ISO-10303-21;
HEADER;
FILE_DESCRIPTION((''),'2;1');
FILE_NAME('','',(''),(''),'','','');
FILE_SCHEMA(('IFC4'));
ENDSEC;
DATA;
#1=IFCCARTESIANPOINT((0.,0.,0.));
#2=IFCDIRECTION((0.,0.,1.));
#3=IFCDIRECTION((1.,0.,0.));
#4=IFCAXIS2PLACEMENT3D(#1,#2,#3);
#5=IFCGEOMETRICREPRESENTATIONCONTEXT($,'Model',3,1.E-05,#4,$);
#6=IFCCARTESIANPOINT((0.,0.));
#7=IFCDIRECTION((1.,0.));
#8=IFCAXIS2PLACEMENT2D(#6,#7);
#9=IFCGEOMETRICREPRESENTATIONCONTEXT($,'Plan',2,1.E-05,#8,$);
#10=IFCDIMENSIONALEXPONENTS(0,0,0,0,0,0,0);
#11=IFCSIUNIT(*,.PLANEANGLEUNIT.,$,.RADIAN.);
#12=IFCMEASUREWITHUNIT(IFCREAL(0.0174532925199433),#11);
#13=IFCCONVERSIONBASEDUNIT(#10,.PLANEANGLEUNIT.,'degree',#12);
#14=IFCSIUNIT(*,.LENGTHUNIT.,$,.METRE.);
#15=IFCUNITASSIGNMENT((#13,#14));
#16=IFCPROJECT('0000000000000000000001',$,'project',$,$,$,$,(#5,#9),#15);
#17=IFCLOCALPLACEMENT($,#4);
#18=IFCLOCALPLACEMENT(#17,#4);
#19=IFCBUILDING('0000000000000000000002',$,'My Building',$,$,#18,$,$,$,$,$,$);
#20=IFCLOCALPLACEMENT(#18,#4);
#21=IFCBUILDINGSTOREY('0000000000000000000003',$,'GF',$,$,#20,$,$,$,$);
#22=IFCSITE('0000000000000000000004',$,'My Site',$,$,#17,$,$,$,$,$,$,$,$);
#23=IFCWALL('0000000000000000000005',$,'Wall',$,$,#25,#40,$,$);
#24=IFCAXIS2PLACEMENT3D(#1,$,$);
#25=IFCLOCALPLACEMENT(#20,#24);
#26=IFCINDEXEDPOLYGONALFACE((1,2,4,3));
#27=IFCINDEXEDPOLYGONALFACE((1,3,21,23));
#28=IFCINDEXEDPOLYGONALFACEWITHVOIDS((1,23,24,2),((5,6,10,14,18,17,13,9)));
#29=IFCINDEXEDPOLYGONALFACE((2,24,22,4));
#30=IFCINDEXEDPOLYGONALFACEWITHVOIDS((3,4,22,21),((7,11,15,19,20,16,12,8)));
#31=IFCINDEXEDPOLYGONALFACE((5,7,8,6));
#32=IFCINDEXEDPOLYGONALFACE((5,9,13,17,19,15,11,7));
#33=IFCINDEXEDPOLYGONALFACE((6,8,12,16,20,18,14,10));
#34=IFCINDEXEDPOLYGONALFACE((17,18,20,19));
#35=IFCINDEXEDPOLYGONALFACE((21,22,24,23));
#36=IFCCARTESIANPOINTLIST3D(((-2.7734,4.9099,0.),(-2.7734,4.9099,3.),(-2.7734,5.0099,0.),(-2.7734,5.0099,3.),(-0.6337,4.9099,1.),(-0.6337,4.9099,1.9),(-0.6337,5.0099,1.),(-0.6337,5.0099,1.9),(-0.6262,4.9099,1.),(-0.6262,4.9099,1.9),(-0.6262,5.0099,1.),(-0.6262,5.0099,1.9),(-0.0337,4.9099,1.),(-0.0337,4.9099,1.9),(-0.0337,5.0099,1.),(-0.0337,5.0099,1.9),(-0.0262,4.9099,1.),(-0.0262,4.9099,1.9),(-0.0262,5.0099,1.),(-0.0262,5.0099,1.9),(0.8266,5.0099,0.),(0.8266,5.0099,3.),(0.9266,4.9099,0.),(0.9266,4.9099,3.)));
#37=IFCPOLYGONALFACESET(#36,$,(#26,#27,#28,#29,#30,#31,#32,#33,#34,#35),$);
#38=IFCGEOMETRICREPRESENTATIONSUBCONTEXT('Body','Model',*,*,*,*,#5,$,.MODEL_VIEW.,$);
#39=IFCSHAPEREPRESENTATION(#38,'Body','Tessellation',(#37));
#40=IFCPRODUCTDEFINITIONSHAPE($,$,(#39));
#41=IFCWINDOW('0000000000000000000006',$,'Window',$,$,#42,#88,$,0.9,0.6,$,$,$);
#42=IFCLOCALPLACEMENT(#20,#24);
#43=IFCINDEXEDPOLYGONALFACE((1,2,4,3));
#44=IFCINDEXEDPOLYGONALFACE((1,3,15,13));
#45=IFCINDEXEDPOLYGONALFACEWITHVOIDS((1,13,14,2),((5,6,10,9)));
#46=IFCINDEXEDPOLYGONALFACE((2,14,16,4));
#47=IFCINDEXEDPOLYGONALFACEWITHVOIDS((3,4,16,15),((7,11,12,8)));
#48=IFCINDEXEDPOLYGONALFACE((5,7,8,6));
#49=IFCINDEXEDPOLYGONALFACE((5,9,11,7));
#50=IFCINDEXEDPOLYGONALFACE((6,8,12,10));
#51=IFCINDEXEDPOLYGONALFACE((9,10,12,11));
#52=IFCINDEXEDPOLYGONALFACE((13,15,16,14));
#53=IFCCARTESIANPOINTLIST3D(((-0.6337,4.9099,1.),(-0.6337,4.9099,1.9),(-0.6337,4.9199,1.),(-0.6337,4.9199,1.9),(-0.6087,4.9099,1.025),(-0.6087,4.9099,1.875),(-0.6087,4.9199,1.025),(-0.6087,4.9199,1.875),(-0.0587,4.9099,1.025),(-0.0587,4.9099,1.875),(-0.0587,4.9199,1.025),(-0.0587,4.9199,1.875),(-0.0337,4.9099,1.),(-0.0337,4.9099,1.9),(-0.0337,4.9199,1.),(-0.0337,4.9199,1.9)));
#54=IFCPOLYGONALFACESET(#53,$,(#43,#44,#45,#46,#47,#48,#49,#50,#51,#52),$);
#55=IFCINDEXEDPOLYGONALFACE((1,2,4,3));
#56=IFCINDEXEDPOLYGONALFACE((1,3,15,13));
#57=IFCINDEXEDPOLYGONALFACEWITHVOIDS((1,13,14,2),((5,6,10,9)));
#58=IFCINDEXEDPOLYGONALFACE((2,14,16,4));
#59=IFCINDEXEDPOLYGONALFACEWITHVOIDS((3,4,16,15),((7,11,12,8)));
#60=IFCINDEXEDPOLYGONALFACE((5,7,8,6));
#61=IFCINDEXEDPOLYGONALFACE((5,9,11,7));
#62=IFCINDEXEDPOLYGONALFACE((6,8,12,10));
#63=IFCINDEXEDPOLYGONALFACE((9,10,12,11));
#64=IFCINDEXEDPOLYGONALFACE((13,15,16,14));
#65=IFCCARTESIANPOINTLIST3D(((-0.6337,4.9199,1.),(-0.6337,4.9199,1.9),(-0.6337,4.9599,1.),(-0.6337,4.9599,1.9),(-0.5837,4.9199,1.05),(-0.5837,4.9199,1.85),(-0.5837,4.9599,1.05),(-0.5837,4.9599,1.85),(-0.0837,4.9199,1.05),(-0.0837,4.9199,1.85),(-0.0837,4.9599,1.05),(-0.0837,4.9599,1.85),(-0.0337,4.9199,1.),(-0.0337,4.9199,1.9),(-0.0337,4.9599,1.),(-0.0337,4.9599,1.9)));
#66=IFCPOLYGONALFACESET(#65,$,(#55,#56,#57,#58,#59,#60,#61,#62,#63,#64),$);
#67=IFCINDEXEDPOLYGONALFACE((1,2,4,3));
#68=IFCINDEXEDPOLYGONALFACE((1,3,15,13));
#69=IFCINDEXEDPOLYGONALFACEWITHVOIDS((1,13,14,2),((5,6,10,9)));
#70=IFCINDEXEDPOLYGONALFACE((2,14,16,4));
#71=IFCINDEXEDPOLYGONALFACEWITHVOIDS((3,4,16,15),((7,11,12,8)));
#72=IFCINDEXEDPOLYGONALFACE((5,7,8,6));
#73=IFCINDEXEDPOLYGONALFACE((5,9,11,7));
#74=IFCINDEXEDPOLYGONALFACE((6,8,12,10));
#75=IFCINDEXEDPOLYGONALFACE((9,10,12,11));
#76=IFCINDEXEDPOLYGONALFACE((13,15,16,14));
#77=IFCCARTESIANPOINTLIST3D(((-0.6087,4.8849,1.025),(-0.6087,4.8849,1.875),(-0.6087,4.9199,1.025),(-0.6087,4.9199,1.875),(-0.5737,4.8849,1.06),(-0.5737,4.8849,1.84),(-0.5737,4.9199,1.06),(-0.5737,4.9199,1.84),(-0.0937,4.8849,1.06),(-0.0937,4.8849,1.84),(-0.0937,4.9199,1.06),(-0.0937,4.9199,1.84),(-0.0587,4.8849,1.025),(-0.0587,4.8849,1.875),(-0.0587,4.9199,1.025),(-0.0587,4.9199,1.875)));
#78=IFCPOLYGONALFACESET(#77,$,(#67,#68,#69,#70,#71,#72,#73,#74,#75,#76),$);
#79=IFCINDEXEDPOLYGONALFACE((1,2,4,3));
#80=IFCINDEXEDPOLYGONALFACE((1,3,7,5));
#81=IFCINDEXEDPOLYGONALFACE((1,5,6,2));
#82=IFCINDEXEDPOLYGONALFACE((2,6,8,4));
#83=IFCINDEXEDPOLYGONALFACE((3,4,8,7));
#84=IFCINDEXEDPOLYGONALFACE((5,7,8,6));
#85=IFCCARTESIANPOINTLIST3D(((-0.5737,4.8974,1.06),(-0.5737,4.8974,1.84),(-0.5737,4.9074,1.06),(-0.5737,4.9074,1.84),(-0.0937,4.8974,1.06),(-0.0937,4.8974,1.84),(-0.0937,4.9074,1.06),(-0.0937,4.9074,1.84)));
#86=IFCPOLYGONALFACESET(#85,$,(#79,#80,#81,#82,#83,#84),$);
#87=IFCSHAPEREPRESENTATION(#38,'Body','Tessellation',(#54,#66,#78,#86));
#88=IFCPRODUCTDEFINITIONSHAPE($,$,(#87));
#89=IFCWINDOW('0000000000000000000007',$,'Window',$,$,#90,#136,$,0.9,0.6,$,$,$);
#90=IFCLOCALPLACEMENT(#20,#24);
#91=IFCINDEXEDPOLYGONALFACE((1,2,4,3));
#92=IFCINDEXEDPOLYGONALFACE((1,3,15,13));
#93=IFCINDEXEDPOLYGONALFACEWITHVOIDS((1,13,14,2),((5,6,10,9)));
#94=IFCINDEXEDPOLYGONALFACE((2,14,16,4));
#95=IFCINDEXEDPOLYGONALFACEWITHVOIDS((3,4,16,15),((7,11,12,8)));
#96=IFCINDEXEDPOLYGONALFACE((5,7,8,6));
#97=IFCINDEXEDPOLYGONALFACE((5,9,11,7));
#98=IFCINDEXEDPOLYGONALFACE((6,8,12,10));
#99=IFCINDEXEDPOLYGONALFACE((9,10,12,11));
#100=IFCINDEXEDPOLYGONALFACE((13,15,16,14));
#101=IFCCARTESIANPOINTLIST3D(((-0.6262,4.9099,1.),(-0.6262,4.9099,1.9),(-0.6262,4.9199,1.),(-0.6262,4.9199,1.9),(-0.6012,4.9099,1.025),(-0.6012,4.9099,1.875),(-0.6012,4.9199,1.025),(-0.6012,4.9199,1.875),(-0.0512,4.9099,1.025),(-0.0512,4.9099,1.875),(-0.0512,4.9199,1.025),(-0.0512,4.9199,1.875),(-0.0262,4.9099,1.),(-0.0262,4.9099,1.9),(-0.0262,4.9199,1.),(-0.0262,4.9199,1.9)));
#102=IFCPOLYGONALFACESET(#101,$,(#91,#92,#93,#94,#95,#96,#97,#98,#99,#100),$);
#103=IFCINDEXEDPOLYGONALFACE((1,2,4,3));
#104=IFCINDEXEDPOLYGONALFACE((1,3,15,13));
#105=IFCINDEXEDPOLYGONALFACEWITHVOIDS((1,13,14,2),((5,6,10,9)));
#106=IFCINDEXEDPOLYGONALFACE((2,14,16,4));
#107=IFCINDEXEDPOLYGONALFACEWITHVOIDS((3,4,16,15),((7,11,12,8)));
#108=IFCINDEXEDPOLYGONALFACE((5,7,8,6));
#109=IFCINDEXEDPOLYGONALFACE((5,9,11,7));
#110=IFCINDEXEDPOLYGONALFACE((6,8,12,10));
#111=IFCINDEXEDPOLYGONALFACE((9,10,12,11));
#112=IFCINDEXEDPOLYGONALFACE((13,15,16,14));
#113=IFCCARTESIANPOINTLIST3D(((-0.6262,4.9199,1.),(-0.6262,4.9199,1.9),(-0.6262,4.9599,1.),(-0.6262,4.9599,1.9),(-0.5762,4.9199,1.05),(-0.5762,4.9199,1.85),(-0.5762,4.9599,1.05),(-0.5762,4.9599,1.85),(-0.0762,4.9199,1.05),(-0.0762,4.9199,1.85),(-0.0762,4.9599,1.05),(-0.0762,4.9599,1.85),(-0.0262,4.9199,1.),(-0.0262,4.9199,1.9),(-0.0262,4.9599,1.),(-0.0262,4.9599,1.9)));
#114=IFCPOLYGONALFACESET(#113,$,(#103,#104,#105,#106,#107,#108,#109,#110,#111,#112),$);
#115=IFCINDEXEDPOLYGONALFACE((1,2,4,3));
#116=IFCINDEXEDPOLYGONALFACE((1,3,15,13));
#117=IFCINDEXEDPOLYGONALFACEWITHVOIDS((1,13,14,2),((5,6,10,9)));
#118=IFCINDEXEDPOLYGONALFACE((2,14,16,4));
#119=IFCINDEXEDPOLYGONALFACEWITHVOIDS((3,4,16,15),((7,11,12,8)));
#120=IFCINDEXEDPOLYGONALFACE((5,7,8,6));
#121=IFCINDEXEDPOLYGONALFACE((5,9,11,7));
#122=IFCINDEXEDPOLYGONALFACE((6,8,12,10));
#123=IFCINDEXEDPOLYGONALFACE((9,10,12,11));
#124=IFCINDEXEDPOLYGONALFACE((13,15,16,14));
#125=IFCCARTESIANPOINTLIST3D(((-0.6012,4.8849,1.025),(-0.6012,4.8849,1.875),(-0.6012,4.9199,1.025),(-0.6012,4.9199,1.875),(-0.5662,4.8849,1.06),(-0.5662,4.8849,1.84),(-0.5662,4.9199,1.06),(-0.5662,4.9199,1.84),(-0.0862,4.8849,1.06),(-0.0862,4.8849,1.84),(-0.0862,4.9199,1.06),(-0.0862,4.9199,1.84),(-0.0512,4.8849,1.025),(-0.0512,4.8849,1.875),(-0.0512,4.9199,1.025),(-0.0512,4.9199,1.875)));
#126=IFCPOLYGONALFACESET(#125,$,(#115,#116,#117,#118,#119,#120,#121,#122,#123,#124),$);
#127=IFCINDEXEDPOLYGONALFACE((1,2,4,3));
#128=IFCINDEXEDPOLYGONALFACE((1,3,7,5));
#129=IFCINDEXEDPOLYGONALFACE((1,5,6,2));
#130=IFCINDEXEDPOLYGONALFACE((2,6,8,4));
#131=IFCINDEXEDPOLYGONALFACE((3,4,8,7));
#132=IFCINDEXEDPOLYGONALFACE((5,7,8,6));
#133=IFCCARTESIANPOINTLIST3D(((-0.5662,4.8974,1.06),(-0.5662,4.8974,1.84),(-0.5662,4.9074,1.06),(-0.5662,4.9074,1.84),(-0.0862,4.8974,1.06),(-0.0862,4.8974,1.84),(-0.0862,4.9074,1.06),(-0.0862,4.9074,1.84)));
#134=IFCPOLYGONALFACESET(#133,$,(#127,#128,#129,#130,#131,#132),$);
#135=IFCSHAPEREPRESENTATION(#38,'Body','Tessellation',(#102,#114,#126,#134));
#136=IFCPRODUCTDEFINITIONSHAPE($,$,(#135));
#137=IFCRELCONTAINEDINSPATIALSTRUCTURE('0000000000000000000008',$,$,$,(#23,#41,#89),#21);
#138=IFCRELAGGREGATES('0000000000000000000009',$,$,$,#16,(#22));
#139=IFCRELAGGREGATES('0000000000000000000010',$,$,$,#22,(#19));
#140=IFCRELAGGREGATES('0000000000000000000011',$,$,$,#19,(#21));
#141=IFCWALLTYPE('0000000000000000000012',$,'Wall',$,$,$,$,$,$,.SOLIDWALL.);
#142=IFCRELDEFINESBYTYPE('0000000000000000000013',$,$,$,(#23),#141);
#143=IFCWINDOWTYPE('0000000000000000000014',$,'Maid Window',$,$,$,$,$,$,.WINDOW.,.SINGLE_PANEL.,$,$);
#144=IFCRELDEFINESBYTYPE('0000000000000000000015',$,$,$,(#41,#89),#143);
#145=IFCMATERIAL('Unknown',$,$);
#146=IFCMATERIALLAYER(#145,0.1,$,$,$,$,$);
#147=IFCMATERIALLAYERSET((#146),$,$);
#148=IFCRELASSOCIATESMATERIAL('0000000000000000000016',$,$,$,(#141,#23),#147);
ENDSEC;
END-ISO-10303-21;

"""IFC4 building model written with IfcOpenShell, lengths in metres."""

from ifc_helpers import new_model, entity, si_unit, converted_unit, frame, origin_with_axes, origin_2d_with_axis, place, context, subcontext, project, spatial, line, indexed_curve, outline, extrude, shape, source, transform, mapped, material, layer, layer_set, layer_usage, type_object, type_shapes, element, fill, save


model = new_model("IFC4")

# Units and contexts
model_context = context("Model", 3, precision=1e-05, world=origin_with_axes())
plan_context = context("Plan", 2, precision=1e-05, world=origin_2d_with_axis())
body_context_1 = subcontext(model_context, "Body", "Model", "MODEL_VIEW")
body_context_2 = subcontext(plan_context, "Body", "Plan", "PLAN_VIEW")
ifc_project = project(units=[converted_unit("PLANEANGLEUNIT", "degree", entity("IfcReal", 0.0174532925199433), si_unit("PLANEANGLEUNIT", "RADIAN"), dimensions=[0, 0, 0, 0, 0, 0, 0]), si_unit("LENGTHUNIT", "METRE")], contexts=[model_context, plan_context])

# Site, building, storey
site_placement = place(None, origin_with_axes())
site = spatial("IfcSite", under=ifc_project, at=site_placement, Name="My Site")
building_placement = place(site_placement, origin_with_axes())
building = spatial("IfcBuilding", under=site, at=building_placement, Name="My Building")
storey_placement = place(building_placement, origin_with_axes())
storey = spatial("IfcBuildingStorey", under=building, at=storey_placement, Name="GF")

# Shared definitions
ifc_material = material(Name="Unknown")

# Shared definitions
ifc_layer_1 = layer(ifc_material, 0.1)
ifc_layer_set_1 = layer_set([ifc_layer_1])
wall_type = type_object("IfcWallType", Name="Wall", PredefinedType="SOLIDWALL", material=ifc_layer_set_1)

# Wall, openings, windows
ifc_layer_usage_1 = layer_usage(ifc_layer_set_1, "AXIS2", "POSITIVE", 0.0)
wall_1_placement = place(storey_placement, frame((0.8266, 5.0099, 0.0), z_axis=(0.0, 0.0, 1.0), x_axis=(-1.0, 0.0, 0.0)))
wall_1 = element("IfcWall", 1, at=wall_1_placement, inside=storey, type_object=wall_type, material=ifc_layer_usage_1, Name="Wall", context=body_context_1, shape_type="SweptSolid", body=[
    extrude(outline(indexed_curve([(0.0, 0.0), (-0.1, 0.1), (3.6, 0.1), (3.6, 0.0)], segments=[line(1, 2, 3, 4, 1)])), origin_with_axes(), (0.0, 0.0, 1.0), 3.0),
])
shared_shape_1 = source(origin_with_axes(), body_context_1, "Body", "SweptSolid", [
    extrude(outline(indexed_curve([(0.0, 0.0), (0.6, 0.0), (0.6, 0.9), (0.0, 0.9)], segments=[line(1, 2, 3, 4, 1)])), frame((0.0, -0.6, 0.0), z_axis=(0.0, -1.0, 0.0), x_axis=(1.0, 0.0, 0.0)), (0.0, 0.0, -1.0), 1.2),
])
opening_1_placement = place(wall_1_placement, frame((0.8604, 0.0, 1.0), z_axis=(0.0, 0.0, 1.0), x_axis=(1.0, 0.0, 0.0)))
opening_1 = element("IfcOpeningElement", 2, at=opening_1_placement, cuts=wall_1, PredefinedType="OPENING", context=body_context_1, shape_type="MappedRepresentation", body=[
    mapped(shared_shape_1, transform((0.0, 0.0, 0.0), x_axis=(1.0, 0.0, 0.0), y_axis=(0.0, 1.0, 0.0), z_axis=(0.0, 0.0, 1.0), scale=1.0)),
])
opening_2_placement = place(wall_1_placement, frame((0.8528, 0.0, 1.0), z_axis=(0.0, 0.0, 1.0), x_axis=(1.0, 0.0, 0.0)))
opening_2 = element("IfcOpeningElement", 3, at=opening_2_placement, cuts=wall_1, PredefinedType="OPENING", context=body_context_1, shape_type="MappedRepresentation", body=[
    mapped(shared_shape_1, transform((0.0, 0.0, 0.0), x_axis=(1.0, 0.0, 0.0), y_axis=(0.0, 1.0, 0.0), z_axis=(0.0, 0.0, 1.0), scale=1.0)),
])
window_type_1 = type_object("IfcWindowType", Name="Maid Window", PartitioningType="SINGLE_PANEL", PredefinedType="WINDOW")
shared_shape_2 = source(origin_with_axes(), body_context_1, "Body", "SweptSolid", [
    extrude(outline(indexed_curve([(0.0, 0.0), (0.6, 0.0), (0.6, 0.9), (0.0, 0.9)], segments=[line(1, 2, 3, 4, 1)]), holes=[indexed_curve([(0.025, 0.025), (0.575, 0.025), (0.575, 0.875), (0.025, 0.875)], segments=[line(1, 2, 3, 4, 1)])]), frame((0.0, 0.09, 0.0), z_axis=(0.0, -1.0, 0.0), x_axis=(1.0, 0.0, 0.0)), (0.0, 0.0, -1.0), 0.01),
    extrude(outline(indexed_curve([(0.0, 0.0), (0.6, 0.0), (0.6, 0.9), (0.0, 0.9)], segments=[line(1, 2, 3, 4, 1)]), holes=[indexed_curve([(0.05, 0.05), (0.55, 0.05), (0.55, 0.85), (0.05, 0.85)], segments=[line(1, 2, 3, 4, 1)])]), frame((0.0, 0.05, 0.0), z_axis=(0.0, -1.0, 0.0), x_axis=(1.0, 0.0, 0.0)), (0.0, 0.0, -1.0), 0.04),
    extrude(outline(indexed_curve([(0.0, 0.0), (0.55, 0.0), (0.55, 0.85), (0.0, 0.85)], segments=[line(1, 2, 3, 4, 1)]), holes=[indexed_curve([(0.035, 0.035), (0.515, 0.035), (0.515, 0.815), (0.035, 0.815)], segments=[line(1, 2, 3, 4, 1)])]), frame((0.025, 0.09, 0.025), z_axis=(0.0, -1.0, 0.0), x_axis=(1.0, 0.0, 0.0)), (0.0, 0.0, -1.0), 0.035),
    extrude(outline(indexed_curve([(0.035, 0.035), (0.515, 0.035), (0.515, 0.815), (0.035, 0.815)], segments=[line(1, 2, 3, 4, 1)])), frame((0.025, 0.1025, 0.025), z_axis=(0.0, -1.0, 0.0), x_axis=(1.0, 0.0, 0.0)), (0.0, 0.0, -1.0), 0.01),
])
shared_shape_3 = source(origin_with_axes(), body_context_2, "Body", "Curve2D", [
    entity("IfcIndexedPolyCurve", entity("IfcCartesianPointList2D", [[0.05, 0.05], [0.55, 0.05]])),
    entity("IfcIndexedPolyCurve", entity("IfcCartesianPointList2D", [[0.0, 0.1], [0.025, 0.1], [0.025, 0.09], [0.05, 0.09], [0.05, 0.05], [0.0, 0.05]]), [entity("IfcLineIndex", [1, 2, 3, 4, 5, 6, 1])]),
    entity("IfcIndexedPolyCurve", entity("IfcCartesianPointList2D", [[0.6, 0.1], [0.575, 0.1], [0.575, 0.09], [0.55, 0.09], [0.55, 0.05], [0.6, 0.05]]), [entity("IfcLineIndex", [1, 2, 3, 4, 5, 6, 1])]),
    entity("IfcIndexedPolyCurve", entity("IfcCartesianPointList2D", [[0.025, 0.09], [0.06, 0.09], [0.06, 0.125], [0.025, 0.125]]), [entity("IfcLineIndex", [1, 2, 3, 4, 1])]),
    entity("IfcIndexedPolyCurve", entity("IfcCartesianPointList2D", [[0.575, 0.09], [0.54, 0.09], [0.54, 0.125], [0.575, 0.125]]), [entity("IfcLineIndex", [1, 2, 3, 4, 1])]),
    entity("IfcIndexedPolyCurve", entity("IfcCartesianPointList2D", [[0.06, 0.09], [0.54, 0.09]])),
    entity("IfcIndexedPolyCurve", entity("IfcCartesianPointList2D", [[0.06, 0.125], [0.54, 0.125]])),
    entity("IfcIndexedPolyCurve", entity("IfcCartesianPointList2D", [[0.06, 0.1075], [0.54, 0.1075]])),
])
type_shapes(window_type_1, [shared_shape_2, shared_shape_3])
window_1_placement = place(opening_1_placement, frame((0.0, 0.0, 0.0), z_axis=(0.0, 0.0, 1.0), x_axis=(1.0, 0.0, 0.0)))
window_1 = element("IfcWindow", 4, at=window_1_placement, inside=storey, type_object=window_type_1, Name="Window", OverallHeight=0.9, OverallWidth=0.6, shapes=[
    shape(body_context_1, "Body", "MappedRepresentation", [mapped(shared_shape_2, transform((0.0, 0.0, 0.0), x_axis=(1.0, 0.0, 0.0), y_axis=(0.0, 1.0, 0.0), z_axis=(0.0, 0.0, 1.0), scale=1.0))]),
    shape(body_context_2, "Body", "MappedRepresentation", [mapped(shared_shape_3, transform((0.0, 0.0, 0.0), x_axis=(1.0, 0.0, 0.0), y_axis=(0.0, 1.0, 0.0), z_axis=(0.0, 0.0, 1.0), scale=1.0))]),
])
fill(opening_1, window_1)
window_2_placement = place(opening_2_placement, frame((0.0, 0.0, 0.0), z_axis=(0.0, 0.0, 1.0), x_axis=(1.0, 0.0, 0.0)))
window_2 = element("IfcWindow", 5, at=window_2_placement, inside=storey, type_object=window_type_1, Name="Window", OverallHeight=0.9, OverallWidth=0.6, shapes=[
    shape(body_context_1, "Body", "MappedRepresentation", [mapped(shared_shape_2, transform((0.0, 0.0, 0.0), x_axis=(1.0, 0.0, 0.0), y_axis=(0.0, 1.0, 0.0), z_axis=(0.0, 0.0, 1.0), scale=1.0))]),
    shape(body_context_2, "Body", "MappedRepresentation", [mapped(shared_shape_3, transform((0.0, 0.0, 0.0), x_axis=(1.0, 0.0, 0.0), y_axis=(0.0, 1.0, 0.0), z_axis=(0.0, 0.0, 1.0), scale=1.0))]),
])
fill(opening_2, window_2)

save(model, "model.ifc")
